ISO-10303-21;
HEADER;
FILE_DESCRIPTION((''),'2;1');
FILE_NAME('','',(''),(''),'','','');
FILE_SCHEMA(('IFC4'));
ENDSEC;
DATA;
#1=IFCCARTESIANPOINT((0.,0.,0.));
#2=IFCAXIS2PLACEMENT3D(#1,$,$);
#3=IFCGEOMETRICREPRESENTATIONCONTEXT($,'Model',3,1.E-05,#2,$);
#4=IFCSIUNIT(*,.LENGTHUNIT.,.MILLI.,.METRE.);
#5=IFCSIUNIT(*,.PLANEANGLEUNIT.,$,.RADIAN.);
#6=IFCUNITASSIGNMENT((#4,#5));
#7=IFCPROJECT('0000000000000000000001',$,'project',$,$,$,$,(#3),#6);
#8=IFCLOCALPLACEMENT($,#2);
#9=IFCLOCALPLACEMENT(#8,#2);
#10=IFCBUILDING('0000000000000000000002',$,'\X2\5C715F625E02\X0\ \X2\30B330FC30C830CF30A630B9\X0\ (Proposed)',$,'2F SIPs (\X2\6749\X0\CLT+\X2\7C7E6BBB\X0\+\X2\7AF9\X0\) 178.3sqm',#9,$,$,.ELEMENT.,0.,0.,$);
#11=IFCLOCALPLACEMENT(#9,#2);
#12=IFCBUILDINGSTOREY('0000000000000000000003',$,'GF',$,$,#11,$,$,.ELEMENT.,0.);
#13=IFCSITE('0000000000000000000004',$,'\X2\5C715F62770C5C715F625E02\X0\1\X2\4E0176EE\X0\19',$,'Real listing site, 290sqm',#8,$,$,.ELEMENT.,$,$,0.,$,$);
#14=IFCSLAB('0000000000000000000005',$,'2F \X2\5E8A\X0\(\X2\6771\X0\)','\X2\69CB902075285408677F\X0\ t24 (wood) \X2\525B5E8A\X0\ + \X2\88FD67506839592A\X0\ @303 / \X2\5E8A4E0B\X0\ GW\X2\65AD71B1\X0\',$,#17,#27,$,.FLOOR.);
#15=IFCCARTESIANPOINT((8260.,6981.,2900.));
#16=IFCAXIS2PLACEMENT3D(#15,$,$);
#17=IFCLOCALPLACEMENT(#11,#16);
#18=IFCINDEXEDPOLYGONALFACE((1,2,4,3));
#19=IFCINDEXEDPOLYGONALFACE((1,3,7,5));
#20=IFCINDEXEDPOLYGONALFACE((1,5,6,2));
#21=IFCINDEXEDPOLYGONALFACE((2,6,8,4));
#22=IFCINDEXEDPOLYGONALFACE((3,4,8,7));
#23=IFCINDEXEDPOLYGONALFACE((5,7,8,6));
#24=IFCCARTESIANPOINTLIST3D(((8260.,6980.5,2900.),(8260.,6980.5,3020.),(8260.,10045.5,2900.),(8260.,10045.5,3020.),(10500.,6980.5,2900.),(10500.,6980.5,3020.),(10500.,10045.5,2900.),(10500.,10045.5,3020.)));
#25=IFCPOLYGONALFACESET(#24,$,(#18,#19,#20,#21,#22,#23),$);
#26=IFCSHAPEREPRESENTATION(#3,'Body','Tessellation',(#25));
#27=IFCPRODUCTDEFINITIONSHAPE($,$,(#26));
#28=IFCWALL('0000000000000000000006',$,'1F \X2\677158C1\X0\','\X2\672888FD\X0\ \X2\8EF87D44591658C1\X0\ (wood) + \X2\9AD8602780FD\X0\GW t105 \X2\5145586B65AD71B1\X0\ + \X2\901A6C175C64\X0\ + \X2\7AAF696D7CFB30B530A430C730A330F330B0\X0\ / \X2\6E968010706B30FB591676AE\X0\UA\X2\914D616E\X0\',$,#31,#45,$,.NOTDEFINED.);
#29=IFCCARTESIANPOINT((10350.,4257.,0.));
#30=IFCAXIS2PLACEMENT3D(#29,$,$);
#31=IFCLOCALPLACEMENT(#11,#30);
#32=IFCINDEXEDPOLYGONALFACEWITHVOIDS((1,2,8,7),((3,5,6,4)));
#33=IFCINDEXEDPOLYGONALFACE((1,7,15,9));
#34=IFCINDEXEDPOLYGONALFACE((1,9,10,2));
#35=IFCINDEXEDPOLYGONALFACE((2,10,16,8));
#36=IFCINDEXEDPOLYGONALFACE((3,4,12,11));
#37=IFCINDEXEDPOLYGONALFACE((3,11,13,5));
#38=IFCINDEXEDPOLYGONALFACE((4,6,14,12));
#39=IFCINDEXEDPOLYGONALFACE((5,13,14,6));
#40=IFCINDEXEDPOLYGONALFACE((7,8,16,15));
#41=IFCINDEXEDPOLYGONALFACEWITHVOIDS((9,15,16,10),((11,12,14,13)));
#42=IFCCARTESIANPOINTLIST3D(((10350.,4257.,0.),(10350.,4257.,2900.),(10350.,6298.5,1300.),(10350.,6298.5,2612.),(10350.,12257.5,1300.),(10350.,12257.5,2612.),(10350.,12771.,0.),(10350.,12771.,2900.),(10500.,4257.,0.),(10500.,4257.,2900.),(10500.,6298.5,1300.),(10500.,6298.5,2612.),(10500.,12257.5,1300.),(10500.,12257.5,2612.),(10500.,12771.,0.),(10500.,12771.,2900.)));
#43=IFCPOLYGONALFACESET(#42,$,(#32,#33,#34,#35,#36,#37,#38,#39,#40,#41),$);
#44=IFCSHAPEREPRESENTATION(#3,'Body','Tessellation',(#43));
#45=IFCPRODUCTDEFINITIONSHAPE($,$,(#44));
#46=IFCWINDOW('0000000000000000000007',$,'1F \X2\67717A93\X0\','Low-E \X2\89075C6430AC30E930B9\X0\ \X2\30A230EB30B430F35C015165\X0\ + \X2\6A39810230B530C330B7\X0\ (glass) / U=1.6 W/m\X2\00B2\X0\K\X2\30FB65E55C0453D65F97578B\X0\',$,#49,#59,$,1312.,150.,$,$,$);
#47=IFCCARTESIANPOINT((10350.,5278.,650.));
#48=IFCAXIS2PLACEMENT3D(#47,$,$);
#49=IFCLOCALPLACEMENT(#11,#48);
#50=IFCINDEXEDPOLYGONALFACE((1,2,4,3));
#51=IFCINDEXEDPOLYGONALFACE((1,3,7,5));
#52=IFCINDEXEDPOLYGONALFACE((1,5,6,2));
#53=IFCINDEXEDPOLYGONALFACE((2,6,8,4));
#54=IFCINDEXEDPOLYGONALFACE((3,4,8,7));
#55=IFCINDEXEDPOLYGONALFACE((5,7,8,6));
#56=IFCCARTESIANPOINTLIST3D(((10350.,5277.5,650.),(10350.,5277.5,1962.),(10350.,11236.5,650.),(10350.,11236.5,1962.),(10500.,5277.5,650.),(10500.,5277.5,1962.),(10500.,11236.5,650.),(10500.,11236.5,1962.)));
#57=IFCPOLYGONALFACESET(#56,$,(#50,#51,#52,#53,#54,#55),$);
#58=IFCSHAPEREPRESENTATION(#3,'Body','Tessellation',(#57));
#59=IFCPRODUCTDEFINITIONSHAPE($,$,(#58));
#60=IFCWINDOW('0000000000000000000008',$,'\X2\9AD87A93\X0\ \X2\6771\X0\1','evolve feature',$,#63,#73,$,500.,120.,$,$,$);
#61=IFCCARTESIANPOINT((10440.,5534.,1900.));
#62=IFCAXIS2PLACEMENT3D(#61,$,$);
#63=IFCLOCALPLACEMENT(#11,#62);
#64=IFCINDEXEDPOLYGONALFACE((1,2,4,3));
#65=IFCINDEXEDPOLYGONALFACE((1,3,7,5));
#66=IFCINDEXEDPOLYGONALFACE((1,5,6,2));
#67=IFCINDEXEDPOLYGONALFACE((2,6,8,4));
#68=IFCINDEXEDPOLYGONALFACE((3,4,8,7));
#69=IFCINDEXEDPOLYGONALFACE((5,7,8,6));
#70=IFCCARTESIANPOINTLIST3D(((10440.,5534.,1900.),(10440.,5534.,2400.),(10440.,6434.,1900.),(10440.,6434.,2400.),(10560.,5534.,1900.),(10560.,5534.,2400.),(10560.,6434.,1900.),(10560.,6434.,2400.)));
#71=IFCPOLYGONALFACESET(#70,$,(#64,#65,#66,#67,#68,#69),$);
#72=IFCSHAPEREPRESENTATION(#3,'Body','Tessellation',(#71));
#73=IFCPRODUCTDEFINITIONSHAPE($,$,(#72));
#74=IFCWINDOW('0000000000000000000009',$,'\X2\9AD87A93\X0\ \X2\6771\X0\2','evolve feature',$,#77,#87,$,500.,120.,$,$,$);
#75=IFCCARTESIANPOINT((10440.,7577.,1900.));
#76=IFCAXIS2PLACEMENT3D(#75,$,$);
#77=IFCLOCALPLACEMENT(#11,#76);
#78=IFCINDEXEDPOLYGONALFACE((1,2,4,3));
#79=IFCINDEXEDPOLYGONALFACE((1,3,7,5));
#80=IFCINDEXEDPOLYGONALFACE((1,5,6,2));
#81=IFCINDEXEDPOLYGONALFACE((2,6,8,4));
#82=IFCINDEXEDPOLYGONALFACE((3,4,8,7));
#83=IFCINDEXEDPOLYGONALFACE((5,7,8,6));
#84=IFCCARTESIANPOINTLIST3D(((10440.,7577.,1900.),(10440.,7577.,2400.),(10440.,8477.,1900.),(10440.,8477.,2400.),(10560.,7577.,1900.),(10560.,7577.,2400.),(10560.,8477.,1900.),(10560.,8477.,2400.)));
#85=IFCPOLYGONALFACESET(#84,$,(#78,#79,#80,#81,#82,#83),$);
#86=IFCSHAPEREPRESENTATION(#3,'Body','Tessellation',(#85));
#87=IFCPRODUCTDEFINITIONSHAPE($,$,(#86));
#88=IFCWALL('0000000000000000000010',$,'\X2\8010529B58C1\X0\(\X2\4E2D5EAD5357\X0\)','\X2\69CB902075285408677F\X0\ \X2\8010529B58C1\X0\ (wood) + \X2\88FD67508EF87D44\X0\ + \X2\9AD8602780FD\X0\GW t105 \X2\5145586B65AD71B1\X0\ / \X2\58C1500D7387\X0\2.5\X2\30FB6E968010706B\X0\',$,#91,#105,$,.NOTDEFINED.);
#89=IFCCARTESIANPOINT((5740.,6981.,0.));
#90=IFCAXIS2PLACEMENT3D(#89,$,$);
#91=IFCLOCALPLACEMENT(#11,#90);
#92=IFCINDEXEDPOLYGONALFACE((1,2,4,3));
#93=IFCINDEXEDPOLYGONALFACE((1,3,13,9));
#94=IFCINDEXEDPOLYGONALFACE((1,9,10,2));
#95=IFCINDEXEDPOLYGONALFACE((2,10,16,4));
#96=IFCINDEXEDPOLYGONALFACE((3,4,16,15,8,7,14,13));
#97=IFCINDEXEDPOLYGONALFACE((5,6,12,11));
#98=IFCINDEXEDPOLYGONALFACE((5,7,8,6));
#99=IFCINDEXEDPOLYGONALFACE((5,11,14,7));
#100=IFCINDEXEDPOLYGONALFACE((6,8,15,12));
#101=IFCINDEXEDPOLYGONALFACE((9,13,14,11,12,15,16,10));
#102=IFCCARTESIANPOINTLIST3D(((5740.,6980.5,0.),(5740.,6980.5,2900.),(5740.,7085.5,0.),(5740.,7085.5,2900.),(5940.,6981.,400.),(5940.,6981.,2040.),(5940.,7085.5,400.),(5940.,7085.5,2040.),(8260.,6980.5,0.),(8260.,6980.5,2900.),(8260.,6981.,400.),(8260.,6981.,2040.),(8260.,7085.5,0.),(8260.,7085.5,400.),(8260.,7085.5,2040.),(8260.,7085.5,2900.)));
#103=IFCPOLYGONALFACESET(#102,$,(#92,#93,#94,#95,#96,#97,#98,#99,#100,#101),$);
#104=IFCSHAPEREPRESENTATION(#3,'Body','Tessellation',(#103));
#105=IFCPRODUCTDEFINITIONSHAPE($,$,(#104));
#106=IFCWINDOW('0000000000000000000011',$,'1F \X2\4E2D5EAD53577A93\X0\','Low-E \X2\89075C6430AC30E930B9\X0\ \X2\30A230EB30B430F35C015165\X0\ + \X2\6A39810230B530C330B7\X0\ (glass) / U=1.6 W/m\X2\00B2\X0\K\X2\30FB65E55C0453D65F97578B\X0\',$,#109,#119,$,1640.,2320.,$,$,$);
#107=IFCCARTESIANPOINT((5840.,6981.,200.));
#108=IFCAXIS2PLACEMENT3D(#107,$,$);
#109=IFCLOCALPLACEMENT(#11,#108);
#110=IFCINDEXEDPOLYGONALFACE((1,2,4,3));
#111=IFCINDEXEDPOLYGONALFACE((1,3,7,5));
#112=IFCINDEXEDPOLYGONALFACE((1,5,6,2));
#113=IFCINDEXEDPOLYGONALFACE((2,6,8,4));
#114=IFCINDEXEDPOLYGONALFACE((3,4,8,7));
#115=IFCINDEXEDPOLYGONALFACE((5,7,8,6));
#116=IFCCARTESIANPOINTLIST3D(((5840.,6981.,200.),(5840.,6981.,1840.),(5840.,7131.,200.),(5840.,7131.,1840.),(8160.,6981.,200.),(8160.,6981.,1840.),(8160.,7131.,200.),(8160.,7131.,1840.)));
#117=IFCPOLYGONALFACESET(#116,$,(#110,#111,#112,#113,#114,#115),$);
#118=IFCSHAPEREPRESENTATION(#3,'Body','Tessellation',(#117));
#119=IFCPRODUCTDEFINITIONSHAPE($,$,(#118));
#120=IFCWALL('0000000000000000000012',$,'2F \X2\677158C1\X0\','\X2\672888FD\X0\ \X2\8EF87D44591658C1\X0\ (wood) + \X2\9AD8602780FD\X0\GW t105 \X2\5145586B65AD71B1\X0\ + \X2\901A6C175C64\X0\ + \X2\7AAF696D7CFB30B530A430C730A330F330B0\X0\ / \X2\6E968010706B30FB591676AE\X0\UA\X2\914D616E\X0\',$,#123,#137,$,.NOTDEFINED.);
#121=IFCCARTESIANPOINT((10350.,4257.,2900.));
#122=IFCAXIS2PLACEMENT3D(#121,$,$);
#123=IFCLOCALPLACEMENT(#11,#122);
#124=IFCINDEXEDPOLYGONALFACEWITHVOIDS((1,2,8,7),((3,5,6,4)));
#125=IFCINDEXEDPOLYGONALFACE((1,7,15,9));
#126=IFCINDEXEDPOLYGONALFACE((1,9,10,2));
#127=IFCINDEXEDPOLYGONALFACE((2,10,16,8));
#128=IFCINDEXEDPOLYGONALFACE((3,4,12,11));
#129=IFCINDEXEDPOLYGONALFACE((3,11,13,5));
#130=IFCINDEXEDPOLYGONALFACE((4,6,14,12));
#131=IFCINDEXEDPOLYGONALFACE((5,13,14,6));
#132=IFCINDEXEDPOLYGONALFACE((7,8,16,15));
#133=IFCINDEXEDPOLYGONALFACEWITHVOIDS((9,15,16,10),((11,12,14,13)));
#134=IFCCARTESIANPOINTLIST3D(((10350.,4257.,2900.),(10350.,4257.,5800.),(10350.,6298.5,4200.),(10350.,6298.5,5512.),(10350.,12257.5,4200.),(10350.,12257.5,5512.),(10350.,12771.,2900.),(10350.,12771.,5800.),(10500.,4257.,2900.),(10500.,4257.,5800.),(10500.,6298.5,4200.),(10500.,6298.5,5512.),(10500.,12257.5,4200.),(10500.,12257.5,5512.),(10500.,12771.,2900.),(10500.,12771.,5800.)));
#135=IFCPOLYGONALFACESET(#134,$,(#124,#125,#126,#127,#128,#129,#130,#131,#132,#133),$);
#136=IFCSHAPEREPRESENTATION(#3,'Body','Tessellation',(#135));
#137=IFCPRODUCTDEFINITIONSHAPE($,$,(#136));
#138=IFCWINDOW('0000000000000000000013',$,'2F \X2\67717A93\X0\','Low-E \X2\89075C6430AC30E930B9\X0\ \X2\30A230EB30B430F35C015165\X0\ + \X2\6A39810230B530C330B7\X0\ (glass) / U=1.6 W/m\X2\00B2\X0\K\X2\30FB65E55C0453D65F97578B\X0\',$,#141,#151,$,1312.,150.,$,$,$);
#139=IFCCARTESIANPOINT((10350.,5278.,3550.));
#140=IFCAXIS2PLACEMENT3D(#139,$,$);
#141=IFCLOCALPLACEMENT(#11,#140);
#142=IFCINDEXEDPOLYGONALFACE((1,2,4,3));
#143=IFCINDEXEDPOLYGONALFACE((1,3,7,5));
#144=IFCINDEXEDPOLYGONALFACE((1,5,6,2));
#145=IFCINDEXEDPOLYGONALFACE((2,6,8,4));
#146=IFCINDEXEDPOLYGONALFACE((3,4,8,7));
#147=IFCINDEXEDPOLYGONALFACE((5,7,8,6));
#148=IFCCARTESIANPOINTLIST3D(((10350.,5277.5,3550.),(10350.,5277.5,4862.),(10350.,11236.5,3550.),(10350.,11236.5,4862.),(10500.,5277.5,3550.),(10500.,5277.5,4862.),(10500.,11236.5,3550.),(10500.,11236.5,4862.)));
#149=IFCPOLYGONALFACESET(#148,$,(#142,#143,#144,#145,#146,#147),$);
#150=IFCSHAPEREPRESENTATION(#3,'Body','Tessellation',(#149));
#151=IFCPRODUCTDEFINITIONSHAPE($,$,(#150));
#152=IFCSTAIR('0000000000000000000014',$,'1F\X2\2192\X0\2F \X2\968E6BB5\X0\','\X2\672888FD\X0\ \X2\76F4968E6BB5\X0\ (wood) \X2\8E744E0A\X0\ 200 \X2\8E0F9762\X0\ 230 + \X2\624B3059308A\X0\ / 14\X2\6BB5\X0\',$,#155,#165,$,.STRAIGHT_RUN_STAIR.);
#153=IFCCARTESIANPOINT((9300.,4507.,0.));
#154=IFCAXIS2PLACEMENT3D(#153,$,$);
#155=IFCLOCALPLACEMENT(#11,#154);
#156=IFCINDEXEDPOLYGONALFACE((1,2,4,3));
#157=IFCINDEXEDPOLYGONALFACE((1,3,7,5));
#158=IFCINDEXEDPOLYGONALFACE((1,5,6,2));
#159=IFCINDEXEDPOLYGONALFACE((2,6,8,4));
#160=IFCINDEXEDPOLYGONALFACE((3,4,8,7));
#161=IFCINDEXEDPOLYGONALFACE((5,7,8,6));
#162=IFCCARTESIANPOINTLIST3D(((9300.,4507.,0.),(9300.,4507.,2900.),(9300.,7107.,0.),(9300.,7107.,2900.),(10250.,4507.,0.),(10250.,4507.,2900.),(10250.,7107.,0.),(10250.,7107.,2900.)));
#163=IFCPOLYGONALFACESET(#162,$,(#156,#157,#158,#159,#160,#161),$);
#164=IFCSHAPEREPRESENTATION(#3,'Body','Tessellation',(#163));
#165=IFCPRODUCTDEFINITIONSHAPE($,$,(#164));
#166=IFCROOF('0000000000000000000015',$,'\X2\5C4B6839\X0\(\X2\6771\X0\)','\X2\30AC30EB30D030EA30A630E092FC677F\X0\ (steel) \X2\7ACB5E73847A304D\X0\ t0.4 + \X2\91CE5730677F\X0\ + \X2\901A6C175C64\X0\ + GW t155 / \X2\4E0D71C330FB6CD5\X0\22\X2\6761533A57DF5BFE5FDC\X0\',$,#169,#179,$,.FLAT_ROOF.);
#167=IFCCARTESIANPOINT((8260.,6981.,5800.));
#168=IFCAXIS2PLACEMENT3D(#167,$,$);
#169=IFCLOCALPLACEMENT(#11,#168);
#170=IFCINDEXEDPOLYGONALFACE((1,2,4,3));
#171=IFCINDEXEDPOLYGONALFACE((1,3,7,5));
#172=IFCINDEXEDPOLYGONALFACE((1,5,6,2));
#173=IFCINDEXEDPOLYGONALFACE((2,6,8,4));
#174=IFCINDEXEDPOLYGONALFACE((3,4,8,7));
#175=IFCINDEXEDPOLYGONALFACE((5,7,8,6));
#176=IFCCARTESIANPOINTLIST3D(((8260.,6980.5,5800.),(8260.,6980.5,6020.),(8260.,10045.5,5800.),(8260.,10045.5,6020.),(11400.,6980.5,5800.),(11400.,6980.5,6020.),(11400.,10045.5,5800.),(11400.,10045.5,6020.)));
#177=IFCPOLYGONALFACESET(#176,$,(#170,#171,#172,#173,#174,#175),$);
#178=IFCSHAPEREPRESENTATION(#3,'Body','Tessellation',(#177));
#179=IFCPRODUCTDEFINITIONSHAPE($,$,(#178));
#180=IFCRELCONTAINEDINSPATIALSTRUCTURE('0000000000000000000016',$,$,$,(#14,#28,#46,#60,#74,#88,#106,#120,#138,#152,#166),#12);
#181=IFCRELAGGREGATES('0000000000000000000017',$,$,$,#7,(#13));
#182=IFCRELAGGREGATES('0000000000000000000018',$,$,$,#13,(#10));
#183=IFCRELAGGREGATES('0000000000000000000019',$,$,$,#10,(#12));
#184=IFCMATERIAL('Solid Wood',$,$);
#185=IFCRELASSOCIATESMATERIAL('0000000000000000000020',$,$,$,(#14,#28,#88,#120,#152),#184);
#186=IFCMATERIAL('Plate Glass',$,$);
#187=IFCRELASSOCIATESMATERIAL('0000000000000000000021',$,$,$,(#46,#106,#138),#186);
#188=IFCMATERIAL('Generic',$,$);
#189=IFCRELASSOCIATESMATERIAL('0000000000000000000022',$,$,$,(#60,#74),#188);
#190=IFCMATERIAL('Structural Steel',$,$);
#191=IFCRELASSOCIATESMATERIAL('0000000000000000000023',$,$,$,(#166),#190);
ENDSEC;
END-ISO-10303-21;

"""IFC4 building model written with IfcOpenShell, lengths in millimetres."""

from ifc_helpers import new_model, si_unit, frame, frame_2d, origin, place, context, project, spatial, rectangle, extrude, material, element, fill, save


model = new_model("IFC4")

# Units and contexts
model_context = context("Model", 3, precision=1e-05, world=origin())
ifc_project = project(units=[si_unit("LENGTHUNIT", "METRE", prefix="MILLI"), si_unit("PLANEANGLEUNIT", "RADIAN")], contexts=[model_context])

# Site, building, storey
site_placement = place(None, origin())
site = spatial("IfcSite", under=ifc_project, at=site_placement, Name="山形県山形市1丁目19", ObjectType="Real listing site, 290sqm", CompositionType="ELEMENT", RefElevation=0.0)
building_placement = place(site_placement, origin())
building = spatial("IfcBuilding", under=site, at=building_placement, Name="山形市 コートハウス (Proposed)", ObjectType="2F SIPs (杉CLT+籾殻+竹) 178.3sqm", CompositionType="ELEMENT", ElevationOfRefHeight=0.0, ElevationOfTerrain=0.0)
storey_placement = place(building_placement, origin())
storey = spatial("IfcBuildingStorey", under=building, at=storey_placement, Name="GF", CompositionType="ELEMENT", Elevation=0.0)

# Slab
ifc_material_1 = material(Name="Solid Wood")
slab_1_placement = place(storey_placement, frame((8260.0, 6981.0, 2900.0)))
element("IfcSlab", 1, at=slab_1_placement, inside=storey, material=ifc_material_1, Name="2F 床(東)", Description="構造用合板 t24 (wood) 剛床 + 製材根太 @303 / 床下 GW断熱", PredefinedType="FLOOR", context=model_context, shape_type="SweptSolid", body=[
    extrude(rectangle(XDim=2240.0, YDim=3065.0, at=frame_2d((1120.0, 1532.0))), frame((8260.0, 6981.0, 2900.0)), (0.0, 0.0, 1.0), 120.0),
])

# Wall, openings, windows
wall_1_placement = place(storey_placement, frame((10350.0, 4257.0, 0.0)))
wall_1 = element("IfcWall", 2, at=wall_1_placement, inside=storey, material=ifc_material_1, Name="1F 東壁", Description="木製 軸組外壁 (wood) + 高性能GW t105 充填断熱 + 通気層 + 窯業系サイディング / 準耐火・外皮UA配慮", PredefinedType="NOTDEFINED", context=model_context, shape_type="SweptSolid", body=[
    extrude(rectangle(XDim=150.0, YDim=8514.0, at=frame_2d((75.0, 4257.0))), frame((10350.0, 4257.0, 0.0)), (0.0, 0.0, 1.0), 2900.0),
])
opening_1_placement = place(storey_placement, frame((10350.0, 5278.0, 650.0)))
opening_1 = element("IfcOpeningElement", 3, at=opening_1_placement, cuts=wall_1, PredefinedType="NOTDEFINED", context=model_context, shape_type="SweptSolid", body=[
    extrude(rectangle(XDim=150.0, YDim=5959.0, at=frame_2d((75.0, 2979.0))), frame((10350.0, 5278.0, 650.0)), (0.0, 0.0, 1.0), 1312.0),
])
opening_2_placement = place(storey_placement, frame((10440.0, 5534.0, 1900.0)))
opening_2 = element("IfcOpeningElement", 4, at=opening_2_placement, cuts=wall_1, PredefinedType="NOTDEFINED", context=model_context, shape_type="SweptSolid", body=[
    extrude(rectangle(XDim=120.0, YDim=900.0, at=frame_2d((60.0, 450.0))), frame((10440.0, 5534.0, 1900.0)), (0.0, 0.0, 1.0), 500.0),
])
opening_3_placement = place(storey_placement, frame((10440.0, 7577.0, 1900.0)))
opening_3 = element("IfcOpeningElement", 5, at=opening_3_placement, cuts=wall_1, PredefinedType="NOTDEFINED", context=model_context, shape_type="SweptSolid", body=[
    extrude(rectangle(XDim=120.0, YDim=900.0, at=frame_2d((60.0, 450.0))), frame((10440.0, 7577.0, 1900.0)), (0.0, 0.0, 1.0), 500.0),
])
ifc_material_2 = material(Name="Plate Glass")
window_1_placement = place(storey_placement, frame((10350.0, 5278.0, 650.0)))
window_1 = element("IfcWindow", 6, at=window_1_placement, inside=storey, material=ifc_material_2, Name="1F 東窓", Description="Low-E 複層ガラス アルゴン封入 + 樹脂サッシ (glass) / U=1.6 W/m²K・日射取得型", OverallHeight=1312.0, OverallWidth=150.0, context=model_context, shape_type="SweptSolid", body=[
    extrude(rectangle(XDim=150.0, YDim=5959.0, at=frame_2d((75.0, 2979.0))), frame((10350.0, 5278.0, 650.0)), (0.0, 0.0, 1.0), 1312.0),
])
fill(opening_1, window_1)
ifc_material_3 = material(Name="Generic")
window_2_placement = place(storey_placement, frame((10440.0, 5534.0, 1900.0)))
window_2 = element("IfcWindow", 7, at=window_2_placement, inside=storey, material=ifc_material_3, Name="高窓 東1", Description="evolve feature", OverallHeight=500.0, OverallWidth=120.0, context=model_context, shape_type="SweptSolid", body=[
    extrude(rectangle(XDim=120.0, YDim=900.0, at=frame_2d((60.0, 450.0))), frame((10440.0, 5534.0, 1900.0)), (0.0, 0.0, 1.0), 500.0),
])
fill(opening_2, window_2)
window_3_placement = place(storey_placement, frame((10440.0, 7577.0, 1900.0)))
window_3 = element("IfcWindow", 8, at=window_3_placement, inside=storey, material=ifc_material_3, Name="高窓 東2", Description="evolve feature", OverallHeight=500.0, OverallWidth=120.0, context=model_context, shape_type="SweptSolid", body=[
    extrude(rectangle(XDim=120.0, YDim=900.0, at=frame_2d((60.0, 450.0))), frame((10440.0, 7577.0, 1900.0)), (0.0, 0.0, 1.0), 500.0),
])
fill(opening_3, window_3)

# Wall, opening, window
wall_2_placement = place(storey_placement, frame((5740.0, 6981.0, 0.0)))
wall_2 = element("IfcWall", 9, at=wall_2_placement, inside=storey, material=ifc_material_1, Name="耐力壁(中庭南)", Description="構造用合板 耐力壁 (wood) + 製材軸組 + 高性能GW t105 充填断熱 / 壁倍率2.5・準耐火", PredefinedType="NOTDEFINED", context=model_context, shape_type="SweptSolid", body=[
    extrude(rectangle(XDim=2520.0, YDim=105.0, at=frame_2d((1260.0, 52.0))), frame((5740.0, 6981.0, 0.0)), (0.0, 0.0, 1.0), 2900.0),
])
opening_4_placement = place(storey_placement, frame((5840.0, 6981.0, 200.0)))
opening_4 = element("IfcOpeningElement", 10, at=opening_4_placement, cuts=wall_2, PredefinedType="NOTDEFINED", context=model_context, shape_type="SweptSolid", body=[
    extrude(rectangle(XDim=2320.0, YDim=150.0, at=frame_2d((1160.0, 75.0))), frame((5840.0, 6981.0, 200.0)), (0.0, 0.0, 1.0), 1640.0),
])
window_4_placement = place(storey_placement, frame((5840.0, 6981.0, 200.0)))
window_4 = element("IfcWindow", 11, at=window_4_placement, inside=storey, material=ifc_material_2, Name="1F 中庭南窓", Description="Low-E 複層ガラス アルゴン封入 + 樹脂サッシ (glass) / U=1.6 W/m²K・日射取得型", OverallHeight=1640.0, OverallWidth=2320.0, context=model_context, shape_type="SweptSolid", body=[
    extrude(rectangle(XDim=2320.0, YDim=150.0, at=frame_2d((1160.0, 75.0))), frame((5840.0, 6981.0, 200.0)), (0.0, 0.0, 1.0), 1640.0),
])
fill(opening_4, window_4)

# Wall, opening, window
wall_3_placement = place(storey_placement, frame((10350.0, 4257.0, 2900.0)))
wall_3 = element("IfcWall", 12, at=wall_3_placement, inside=storey, material=ifc_material_1, Name="2F 東壁", Description="木製 軸組外壁 (wood) + 高性能GW t105 充填断熱 + 通気層 + 窯業系サイディング / 準耐火・外皮UA配慮", PredefinedType="NOTDEFINED", context=model_context, shape_type="SweptSolid", body=[
    extrude(rectangle(XDim=150.0, YDim=8514.0, at=frame_2d((75.0, 4257.0))), frame((10350.0, 4257.0, 2900.0)), (0.0, 0.0, 1.0), 2900.0),
])
opening_5_placement = place(storey_placement, frame((10350.0, 5278.0, 3550.0)))
opening_5 = element("IfcOpeningElement", 13, at=opening_5_placement, cuts=wall_3, PredefinedType="NOTDEFINED", context=model_context, shape_type="SweptSolid", body=[
    extrude(rectangle(XDim=150.0, YDim=5959.0, at=frame_2d((75.0, 2979.0))), frame((10350.0, 5278.0, 3550.0)), (0.0, 0.0, 1.0), 1312.0),
])
window_5_placement = place(storey_placement, frame((10350.0, 5278.0, 3550.0)))
window_5 = element("IfcWindow", 14, at=window_5_placement, inside=storey, material=ifc_material_2, Name="2F 東窓", Description="Low-E 複層ガラス アルゴン封入 + 樹脂サッシ (glass) / U=1.6 W/m²K・日射取得型", OverallHeight=1312.0, OverallWidth=150.0, context=model_context, shape_type="SweptSolid", body=[
    extrude(rectangle(XDim=150.0, YDim=5959.0, at=frame_2d((75.0, 2979.0))), frame((10350.0, 5278.0, 3550.0)), (0.0, 0.0, 1.0), 1312.0),
])
fill(opening_5, window_5)

# Stair
stair_placement = place(storey_placement, frame((9300.0, 4507.0, 0.0)))
element("IfcStair", 15, at=stair_placement, inside=storey, material=ifc_material_1, Name="1F→2F 階段", Description="木製 直階段 (wood) 蹴上 200 踏面 230 + 手すり / 14段", PredefinedType="STRAIGHT_RUN_STAIR", context=model_context, shape_type="SweptSolid", body=[
    extrude(rectangle(XDim=950.0, YDim=2600.0, at=frame_2d((475.0, 1300.0))), frame((9300.0, 4507.0, 0.0)), (0.0, 0.0, 1.0), 2900.0),
])

# Roof
ifc_material_4 = material(Name="Structural Steel")
roof_placement = place(storey_placement, frame((8260.0, 6981.0, 5800.0)))
element("IfcRoof", 16, at=roof_placement, inside=storey, material=ifc_material_4, Name="屋根(東)", Description="ガルバリウム鋼板 (steel) 立平葺き t0.4 + 野地板 + 通気層 + GW t155 / 不燃・法22条区域対応", PredefinedType="FLAT_ROOF", context=model_context, shape_type="SweptSolid", body=[
    extrude(rectangle(XDim=3140.0, YDim=3065.0, at=frame_2d((1570.0, 1532.0))), frame((8260.0, 6981.0, 5800.0)), (0.0, 0.0, 1.0), 220.0),
])

save(model, "model.ifc")
